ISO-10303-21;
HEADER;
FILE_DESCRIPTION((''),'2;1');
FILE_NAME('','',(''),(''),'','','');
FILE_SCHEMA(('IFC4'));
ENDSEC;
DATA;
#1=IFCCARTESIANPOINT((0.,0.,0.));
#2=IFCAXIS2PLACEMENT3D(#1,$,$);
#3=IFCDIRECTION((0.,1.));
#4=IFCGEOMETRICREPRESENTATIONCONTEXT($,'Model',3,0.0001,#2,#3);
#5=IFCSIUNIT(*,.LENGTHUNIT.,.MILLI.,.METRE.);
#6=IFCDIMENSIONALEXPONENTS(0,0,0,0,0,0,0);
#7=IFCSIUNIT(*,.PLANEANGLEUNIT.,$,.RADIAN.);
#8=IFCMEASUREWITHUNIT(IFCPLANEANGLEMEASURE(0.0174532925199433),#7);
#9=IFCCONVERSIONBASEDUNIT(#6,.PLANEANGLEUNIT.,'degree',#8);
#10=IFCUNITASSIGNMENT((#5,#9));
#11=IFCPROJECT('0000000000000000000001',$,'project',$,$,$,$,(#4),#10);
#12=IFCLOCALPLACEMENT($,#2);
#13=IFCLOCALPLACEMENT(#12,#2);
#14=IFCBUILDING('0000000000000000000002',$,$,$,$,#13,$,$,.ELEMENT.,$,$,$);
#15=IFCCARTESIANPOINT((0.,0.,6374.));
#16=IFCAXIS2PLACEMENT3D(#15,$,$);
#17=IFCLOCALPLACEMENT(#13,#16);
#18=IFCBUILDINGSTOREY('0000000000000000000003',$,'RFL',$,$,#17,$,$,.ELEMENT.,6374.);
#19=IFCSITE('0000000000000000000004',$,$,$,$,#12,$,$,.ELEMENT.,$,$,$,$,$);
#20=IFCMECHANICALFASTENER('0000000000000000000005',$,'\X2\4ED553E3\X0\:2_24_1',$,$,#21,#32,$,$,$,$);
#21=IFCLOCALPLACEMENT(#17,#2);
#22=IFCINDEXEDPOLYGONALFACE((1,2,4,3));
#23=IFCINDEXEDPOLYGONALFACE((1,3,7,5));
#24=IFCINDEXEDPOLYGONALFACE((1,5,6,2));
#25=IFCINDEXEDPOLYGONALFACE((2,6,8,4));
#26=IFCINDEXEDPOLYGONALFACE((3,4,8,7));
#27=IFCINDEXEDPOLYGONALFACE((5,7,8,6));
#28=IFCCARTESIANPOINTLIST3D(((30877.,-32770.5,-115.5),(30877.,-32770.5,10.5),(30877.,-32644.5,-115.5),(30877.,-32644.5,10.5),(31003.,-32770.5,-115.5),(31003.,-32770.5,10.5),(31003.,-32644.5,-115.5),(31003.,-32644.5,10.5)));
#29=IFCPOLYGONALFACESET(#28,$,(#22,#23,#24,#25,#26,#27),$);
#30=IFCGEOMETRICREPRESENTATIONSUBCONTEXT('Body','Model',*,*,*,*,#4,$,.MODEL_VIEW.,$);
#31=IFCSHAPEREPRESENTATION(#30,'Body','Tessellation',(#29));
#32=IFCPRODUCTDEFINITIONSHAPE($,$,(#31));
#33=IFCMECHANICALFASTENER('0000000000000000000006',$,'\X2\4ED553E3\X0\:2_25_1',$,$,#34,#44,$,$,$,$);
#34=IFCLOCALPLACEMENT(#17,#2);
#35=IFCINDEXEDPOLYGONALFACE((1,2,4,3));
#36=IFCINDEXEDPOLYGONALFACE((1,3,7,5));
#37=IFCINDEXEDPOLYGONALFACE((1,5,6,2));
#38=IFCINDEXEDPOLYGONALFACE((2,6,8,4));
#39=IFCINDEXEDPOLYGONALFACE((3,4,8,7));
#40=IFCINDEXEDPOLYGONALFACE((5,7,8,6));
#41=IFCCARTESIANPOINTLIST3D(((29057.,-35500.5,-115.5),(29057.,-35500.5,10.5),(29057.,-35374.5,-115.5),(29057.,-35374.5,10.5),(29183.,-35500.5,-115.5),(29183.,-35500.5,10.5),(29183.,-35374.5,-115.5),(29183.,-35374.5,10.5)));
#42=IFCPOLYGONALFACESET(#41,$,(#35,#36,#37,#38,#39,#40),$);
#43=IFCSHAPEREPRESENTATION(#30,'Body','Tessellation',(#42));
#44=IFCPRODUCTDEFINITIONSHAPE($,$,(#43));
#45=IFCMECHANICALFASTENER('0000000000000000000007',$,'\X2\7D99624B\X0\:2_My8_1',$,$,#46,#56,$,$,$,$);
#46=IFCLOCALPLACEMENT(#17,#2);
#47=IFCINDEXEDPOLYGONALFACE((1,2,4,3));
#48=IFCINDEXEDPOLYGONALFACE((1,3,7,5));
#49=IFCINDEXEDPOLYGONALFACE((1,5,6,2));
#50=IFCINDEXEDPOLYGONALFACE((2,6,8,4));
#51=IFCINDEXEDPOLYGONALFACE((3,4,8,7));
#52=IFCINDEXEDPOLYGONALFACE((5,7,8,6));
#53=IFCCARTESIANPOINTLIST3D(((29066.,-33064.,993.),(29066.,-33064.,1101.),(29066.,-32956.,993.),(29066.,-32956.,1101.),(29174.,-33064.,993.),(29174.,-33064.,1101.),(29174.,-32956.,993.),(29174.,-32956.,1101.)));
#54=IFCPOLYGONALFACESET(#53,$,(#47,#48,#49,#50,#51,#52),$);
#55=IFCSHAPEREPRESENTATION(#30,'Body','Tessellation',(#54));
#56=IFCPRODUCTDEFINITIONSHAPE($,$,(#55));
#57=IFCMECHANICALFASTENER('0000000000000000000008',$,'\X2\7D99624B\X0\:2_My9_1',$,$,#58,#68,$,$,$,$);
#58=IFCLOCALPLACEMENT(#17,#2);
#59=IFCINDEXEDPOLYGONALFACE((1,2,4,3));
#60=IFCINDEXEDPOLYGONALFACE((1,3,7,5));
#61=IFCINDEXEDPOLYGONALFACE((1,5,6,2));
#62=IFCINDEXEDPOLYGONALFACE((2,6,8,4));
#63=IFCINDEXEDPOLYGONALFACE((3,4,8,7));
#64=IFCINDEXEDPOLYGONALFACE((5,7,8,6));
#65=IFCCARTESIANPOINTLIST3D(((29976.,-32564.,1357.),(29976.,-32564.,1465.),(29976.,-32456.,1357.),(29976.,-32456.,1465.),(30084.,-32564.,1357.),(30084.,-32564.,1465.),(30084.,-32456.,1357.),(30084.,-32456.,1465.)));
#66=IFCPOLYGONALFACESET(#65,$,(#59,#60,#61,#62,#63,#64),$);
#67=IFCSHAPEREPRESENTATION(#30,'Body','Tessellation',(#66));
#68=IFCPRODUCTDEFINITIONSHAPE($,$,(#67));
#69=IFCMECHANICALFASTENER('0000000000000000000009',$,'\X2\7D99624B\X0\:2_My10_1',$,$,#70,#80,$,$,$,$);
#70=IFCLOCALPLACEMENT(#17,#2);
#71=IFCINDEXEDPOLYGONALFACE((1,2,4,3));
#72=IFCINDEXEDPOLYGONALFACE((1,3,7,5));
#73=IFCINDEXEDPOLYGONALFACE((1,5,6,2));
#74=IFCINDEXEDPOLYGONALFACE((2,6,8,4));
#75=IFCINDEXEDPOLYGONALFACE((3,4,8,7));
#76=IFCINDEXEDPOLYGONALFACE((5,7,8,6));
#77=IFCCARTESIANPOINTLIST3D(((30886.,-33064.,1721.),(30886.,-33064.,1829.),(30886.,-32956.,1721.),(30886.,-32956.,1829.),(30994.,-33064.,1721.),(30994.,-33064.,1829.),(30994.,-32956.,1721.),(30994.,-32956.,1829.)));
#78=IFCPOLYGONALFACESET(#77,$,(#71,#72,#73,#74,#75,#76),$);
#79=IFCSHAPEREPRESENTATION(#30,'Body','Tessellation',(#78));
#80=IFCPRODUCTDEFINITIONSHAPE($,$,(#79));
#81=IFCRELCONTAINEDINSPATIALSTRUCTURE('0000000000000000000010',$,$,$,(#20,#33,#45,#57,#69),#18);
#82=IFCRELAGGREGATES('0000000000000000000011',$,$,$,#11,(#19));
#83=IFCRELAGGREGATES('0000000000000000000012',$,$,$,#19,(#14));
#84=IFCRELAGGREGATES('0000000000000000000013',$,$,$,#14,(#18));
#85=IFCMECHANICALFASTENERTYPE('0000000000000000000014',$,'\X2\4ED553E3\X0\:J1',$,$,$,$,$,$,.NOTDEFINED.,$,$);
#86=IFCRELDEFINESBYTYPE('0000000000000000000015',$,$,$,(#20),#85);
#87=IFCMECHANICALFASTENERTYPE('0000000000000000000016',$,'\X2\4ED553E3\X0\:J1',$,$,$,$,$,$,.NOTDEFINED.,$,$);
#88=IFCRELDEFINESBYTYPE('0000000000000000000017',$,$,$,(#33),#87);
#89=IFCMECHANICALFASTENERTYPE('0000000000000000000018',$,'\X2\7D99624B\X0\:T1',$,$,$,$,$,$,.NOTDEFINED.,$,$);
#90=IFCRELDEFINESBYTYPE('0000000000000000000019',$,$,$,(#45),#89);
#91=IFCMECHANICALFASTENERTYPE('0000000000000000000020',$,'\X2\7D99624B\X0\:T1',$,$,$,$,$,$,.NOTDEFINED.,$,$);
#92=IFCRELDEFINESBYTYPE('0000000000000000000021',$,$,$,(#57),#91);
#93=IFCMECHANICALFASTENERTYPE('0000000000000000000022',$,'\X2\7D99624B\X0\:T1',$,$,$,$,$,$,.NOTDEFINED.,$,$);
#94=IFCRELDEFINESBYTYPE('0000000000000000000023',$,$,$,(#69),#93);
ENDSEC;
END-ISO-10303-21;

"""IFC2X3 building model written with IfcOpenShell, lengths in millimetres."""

from ifc_helpers import new_model, entity, si_unit, converted_unit, direction, frame, origin, origin_with_axes, origin_2d, place, context, subcontext, project, spatial, rectangle, extrude, type_object, element, save


model = new_model("IFC2X3")

# Units and contexts
model_context = context("Model", 3, precision=0.0001, world=origin(), true_north=direction((0.0, 1.0)))
body_context = subcontext(model_context, "Body", "Model", "MODEL_VIEW")
ifc_project = project(units=[si_unit("LENGTHUNIT", "METRE", prefix="MILLI"), converted_unit("PLANEANGLEUNIT", "degree", entity("IfcPlaneAngleMeasure", 0.0174532925199433), si_unit("PLANEANGLEUNIT", "RADIAN"), dimensions=[0, 0, 0, 0, 0, 0, 0])], contexts=[model_context])

# Site, building, storey
site_placement = place(None, origin())
site = spatial("IfcSite", under=ifc_project, at=site_placement, CompositionType="ELEMENT")
building_placement = place(site_placement, origin())
building = spatial("IfcBuilding", under=site, at=building_placement, CompositionType="ELEMENT")
storey_placement = place(building_placement, frame((0.0, 0.0, 6374.0)))
storey = spatial("IfcBuildingStorey", under=building, at=storey_placement, Name="RFL", CompositionType="ELEMENT", Elevation=6374.0)

# Mechanical fasteners
mechanical_fastener_type_1 = type_object("IfcMechanicalFastenerType", Name="仕口:J1")
mechanical_fastener_1_placement = place(storey_placement, frame((30940.0, -32707.5, -115.5)))
element("IfcMechanicalFastener", 1, at=mechanical_fastener_1_placement, inside=storey, type_object=mechanical_fastener_type_1, Name="仕口:2_24_1", context=body_context, shape_type="SweptSolid", body=[
    extrude(rectangle(XDim=126.0, YDim=126.0, at=origin_2d()), origin_with_axes(), (0.0, 0.0, 1.0), 126.0),
])
mechanical_fastener_type_2 = type_object("IfcMechanicalFastenerType", Name="仕口:J1")
mechanical_fastener_2_placement = place(storey_placement, frame((29120.0, -35437.5, -115.5)))
element("IfcMechanicalFastener", 2, at=mechanical_fastener_2_placement, inside=storey, type_object=mechanical_fastener_type_2, Name="仕口:2_25_1", context=body_context, shape_type="SweptSolid", body=[
    extrude(rectangle(XDim=126.0, YDim=126.0, at=origin_2d()), origin_with_axes(), (0.0, 0.0, 1.0), 126.0),
])
mechanical_fastener_type_3 = type_object("IfcMechanicalFastenerType", Name="継手:T1")
mechanical_fastener_3_placement = place(storey_placement, frame((29120.0, -33010.0, 993.0)))
element("IfcMechanicalFastener", 3, at=mechanical_fastener_3_placement, inside=storey, type_object=mechanical_fastener_type_3, Name="継手:2_My8_1", context=body_context, shape_type="SweptSolid", body=[
    extrude(rectangle(XDim=108.0, YDim=108.0, at=origin_2d()), origin_with_axes(), (0.0, 0.0, 1.0), 108.0),
])
mechanical_fastener_type_4 = type_object("IfcMechanicalFastenerType", Name="継手:T1")
mechanical_fastener_4_placement = place(storey_placement, frame((30030.0, -32510.0, 1357.0)))
element("IfcMechanicalFastener", 4, at=mechanical_fastener_4_placement, inside=storey, type_object=mechanical_fastener_type_4, Name="継手:2_My9_1", context=body_context, shape_type="SweptSolid", body=[
    extrude(rectangle(XDim=108.0, YDim=108.0, at=origin_2d()), origin_with_axes(), (0.0, 0.0, 1.0), 108.0),
])
mechanical_fastener_type_5 = type_object("IfcMechanicalFastenerType", Name="継手:T1")
mechanical_fastener_5_placement = place(storey_placement, frame((30940.0, -33010.0, 1721.0)))
element("IfcMechanicalFastener", 5, at=mechanical_fastener_5_placement, inside=storey, type_object=mechanical_fastener_type_5, Name="継手:2_My10_1", context=body_context, shape_type="SweptSolid", body=[
    extrude(rectangle(XDim=108.0, YDim=108.0, at=origin_2d()), origin_with_axes(), (0.0, 0.0, 1.0), 108.0),
])

save(model, "model.ifc")
